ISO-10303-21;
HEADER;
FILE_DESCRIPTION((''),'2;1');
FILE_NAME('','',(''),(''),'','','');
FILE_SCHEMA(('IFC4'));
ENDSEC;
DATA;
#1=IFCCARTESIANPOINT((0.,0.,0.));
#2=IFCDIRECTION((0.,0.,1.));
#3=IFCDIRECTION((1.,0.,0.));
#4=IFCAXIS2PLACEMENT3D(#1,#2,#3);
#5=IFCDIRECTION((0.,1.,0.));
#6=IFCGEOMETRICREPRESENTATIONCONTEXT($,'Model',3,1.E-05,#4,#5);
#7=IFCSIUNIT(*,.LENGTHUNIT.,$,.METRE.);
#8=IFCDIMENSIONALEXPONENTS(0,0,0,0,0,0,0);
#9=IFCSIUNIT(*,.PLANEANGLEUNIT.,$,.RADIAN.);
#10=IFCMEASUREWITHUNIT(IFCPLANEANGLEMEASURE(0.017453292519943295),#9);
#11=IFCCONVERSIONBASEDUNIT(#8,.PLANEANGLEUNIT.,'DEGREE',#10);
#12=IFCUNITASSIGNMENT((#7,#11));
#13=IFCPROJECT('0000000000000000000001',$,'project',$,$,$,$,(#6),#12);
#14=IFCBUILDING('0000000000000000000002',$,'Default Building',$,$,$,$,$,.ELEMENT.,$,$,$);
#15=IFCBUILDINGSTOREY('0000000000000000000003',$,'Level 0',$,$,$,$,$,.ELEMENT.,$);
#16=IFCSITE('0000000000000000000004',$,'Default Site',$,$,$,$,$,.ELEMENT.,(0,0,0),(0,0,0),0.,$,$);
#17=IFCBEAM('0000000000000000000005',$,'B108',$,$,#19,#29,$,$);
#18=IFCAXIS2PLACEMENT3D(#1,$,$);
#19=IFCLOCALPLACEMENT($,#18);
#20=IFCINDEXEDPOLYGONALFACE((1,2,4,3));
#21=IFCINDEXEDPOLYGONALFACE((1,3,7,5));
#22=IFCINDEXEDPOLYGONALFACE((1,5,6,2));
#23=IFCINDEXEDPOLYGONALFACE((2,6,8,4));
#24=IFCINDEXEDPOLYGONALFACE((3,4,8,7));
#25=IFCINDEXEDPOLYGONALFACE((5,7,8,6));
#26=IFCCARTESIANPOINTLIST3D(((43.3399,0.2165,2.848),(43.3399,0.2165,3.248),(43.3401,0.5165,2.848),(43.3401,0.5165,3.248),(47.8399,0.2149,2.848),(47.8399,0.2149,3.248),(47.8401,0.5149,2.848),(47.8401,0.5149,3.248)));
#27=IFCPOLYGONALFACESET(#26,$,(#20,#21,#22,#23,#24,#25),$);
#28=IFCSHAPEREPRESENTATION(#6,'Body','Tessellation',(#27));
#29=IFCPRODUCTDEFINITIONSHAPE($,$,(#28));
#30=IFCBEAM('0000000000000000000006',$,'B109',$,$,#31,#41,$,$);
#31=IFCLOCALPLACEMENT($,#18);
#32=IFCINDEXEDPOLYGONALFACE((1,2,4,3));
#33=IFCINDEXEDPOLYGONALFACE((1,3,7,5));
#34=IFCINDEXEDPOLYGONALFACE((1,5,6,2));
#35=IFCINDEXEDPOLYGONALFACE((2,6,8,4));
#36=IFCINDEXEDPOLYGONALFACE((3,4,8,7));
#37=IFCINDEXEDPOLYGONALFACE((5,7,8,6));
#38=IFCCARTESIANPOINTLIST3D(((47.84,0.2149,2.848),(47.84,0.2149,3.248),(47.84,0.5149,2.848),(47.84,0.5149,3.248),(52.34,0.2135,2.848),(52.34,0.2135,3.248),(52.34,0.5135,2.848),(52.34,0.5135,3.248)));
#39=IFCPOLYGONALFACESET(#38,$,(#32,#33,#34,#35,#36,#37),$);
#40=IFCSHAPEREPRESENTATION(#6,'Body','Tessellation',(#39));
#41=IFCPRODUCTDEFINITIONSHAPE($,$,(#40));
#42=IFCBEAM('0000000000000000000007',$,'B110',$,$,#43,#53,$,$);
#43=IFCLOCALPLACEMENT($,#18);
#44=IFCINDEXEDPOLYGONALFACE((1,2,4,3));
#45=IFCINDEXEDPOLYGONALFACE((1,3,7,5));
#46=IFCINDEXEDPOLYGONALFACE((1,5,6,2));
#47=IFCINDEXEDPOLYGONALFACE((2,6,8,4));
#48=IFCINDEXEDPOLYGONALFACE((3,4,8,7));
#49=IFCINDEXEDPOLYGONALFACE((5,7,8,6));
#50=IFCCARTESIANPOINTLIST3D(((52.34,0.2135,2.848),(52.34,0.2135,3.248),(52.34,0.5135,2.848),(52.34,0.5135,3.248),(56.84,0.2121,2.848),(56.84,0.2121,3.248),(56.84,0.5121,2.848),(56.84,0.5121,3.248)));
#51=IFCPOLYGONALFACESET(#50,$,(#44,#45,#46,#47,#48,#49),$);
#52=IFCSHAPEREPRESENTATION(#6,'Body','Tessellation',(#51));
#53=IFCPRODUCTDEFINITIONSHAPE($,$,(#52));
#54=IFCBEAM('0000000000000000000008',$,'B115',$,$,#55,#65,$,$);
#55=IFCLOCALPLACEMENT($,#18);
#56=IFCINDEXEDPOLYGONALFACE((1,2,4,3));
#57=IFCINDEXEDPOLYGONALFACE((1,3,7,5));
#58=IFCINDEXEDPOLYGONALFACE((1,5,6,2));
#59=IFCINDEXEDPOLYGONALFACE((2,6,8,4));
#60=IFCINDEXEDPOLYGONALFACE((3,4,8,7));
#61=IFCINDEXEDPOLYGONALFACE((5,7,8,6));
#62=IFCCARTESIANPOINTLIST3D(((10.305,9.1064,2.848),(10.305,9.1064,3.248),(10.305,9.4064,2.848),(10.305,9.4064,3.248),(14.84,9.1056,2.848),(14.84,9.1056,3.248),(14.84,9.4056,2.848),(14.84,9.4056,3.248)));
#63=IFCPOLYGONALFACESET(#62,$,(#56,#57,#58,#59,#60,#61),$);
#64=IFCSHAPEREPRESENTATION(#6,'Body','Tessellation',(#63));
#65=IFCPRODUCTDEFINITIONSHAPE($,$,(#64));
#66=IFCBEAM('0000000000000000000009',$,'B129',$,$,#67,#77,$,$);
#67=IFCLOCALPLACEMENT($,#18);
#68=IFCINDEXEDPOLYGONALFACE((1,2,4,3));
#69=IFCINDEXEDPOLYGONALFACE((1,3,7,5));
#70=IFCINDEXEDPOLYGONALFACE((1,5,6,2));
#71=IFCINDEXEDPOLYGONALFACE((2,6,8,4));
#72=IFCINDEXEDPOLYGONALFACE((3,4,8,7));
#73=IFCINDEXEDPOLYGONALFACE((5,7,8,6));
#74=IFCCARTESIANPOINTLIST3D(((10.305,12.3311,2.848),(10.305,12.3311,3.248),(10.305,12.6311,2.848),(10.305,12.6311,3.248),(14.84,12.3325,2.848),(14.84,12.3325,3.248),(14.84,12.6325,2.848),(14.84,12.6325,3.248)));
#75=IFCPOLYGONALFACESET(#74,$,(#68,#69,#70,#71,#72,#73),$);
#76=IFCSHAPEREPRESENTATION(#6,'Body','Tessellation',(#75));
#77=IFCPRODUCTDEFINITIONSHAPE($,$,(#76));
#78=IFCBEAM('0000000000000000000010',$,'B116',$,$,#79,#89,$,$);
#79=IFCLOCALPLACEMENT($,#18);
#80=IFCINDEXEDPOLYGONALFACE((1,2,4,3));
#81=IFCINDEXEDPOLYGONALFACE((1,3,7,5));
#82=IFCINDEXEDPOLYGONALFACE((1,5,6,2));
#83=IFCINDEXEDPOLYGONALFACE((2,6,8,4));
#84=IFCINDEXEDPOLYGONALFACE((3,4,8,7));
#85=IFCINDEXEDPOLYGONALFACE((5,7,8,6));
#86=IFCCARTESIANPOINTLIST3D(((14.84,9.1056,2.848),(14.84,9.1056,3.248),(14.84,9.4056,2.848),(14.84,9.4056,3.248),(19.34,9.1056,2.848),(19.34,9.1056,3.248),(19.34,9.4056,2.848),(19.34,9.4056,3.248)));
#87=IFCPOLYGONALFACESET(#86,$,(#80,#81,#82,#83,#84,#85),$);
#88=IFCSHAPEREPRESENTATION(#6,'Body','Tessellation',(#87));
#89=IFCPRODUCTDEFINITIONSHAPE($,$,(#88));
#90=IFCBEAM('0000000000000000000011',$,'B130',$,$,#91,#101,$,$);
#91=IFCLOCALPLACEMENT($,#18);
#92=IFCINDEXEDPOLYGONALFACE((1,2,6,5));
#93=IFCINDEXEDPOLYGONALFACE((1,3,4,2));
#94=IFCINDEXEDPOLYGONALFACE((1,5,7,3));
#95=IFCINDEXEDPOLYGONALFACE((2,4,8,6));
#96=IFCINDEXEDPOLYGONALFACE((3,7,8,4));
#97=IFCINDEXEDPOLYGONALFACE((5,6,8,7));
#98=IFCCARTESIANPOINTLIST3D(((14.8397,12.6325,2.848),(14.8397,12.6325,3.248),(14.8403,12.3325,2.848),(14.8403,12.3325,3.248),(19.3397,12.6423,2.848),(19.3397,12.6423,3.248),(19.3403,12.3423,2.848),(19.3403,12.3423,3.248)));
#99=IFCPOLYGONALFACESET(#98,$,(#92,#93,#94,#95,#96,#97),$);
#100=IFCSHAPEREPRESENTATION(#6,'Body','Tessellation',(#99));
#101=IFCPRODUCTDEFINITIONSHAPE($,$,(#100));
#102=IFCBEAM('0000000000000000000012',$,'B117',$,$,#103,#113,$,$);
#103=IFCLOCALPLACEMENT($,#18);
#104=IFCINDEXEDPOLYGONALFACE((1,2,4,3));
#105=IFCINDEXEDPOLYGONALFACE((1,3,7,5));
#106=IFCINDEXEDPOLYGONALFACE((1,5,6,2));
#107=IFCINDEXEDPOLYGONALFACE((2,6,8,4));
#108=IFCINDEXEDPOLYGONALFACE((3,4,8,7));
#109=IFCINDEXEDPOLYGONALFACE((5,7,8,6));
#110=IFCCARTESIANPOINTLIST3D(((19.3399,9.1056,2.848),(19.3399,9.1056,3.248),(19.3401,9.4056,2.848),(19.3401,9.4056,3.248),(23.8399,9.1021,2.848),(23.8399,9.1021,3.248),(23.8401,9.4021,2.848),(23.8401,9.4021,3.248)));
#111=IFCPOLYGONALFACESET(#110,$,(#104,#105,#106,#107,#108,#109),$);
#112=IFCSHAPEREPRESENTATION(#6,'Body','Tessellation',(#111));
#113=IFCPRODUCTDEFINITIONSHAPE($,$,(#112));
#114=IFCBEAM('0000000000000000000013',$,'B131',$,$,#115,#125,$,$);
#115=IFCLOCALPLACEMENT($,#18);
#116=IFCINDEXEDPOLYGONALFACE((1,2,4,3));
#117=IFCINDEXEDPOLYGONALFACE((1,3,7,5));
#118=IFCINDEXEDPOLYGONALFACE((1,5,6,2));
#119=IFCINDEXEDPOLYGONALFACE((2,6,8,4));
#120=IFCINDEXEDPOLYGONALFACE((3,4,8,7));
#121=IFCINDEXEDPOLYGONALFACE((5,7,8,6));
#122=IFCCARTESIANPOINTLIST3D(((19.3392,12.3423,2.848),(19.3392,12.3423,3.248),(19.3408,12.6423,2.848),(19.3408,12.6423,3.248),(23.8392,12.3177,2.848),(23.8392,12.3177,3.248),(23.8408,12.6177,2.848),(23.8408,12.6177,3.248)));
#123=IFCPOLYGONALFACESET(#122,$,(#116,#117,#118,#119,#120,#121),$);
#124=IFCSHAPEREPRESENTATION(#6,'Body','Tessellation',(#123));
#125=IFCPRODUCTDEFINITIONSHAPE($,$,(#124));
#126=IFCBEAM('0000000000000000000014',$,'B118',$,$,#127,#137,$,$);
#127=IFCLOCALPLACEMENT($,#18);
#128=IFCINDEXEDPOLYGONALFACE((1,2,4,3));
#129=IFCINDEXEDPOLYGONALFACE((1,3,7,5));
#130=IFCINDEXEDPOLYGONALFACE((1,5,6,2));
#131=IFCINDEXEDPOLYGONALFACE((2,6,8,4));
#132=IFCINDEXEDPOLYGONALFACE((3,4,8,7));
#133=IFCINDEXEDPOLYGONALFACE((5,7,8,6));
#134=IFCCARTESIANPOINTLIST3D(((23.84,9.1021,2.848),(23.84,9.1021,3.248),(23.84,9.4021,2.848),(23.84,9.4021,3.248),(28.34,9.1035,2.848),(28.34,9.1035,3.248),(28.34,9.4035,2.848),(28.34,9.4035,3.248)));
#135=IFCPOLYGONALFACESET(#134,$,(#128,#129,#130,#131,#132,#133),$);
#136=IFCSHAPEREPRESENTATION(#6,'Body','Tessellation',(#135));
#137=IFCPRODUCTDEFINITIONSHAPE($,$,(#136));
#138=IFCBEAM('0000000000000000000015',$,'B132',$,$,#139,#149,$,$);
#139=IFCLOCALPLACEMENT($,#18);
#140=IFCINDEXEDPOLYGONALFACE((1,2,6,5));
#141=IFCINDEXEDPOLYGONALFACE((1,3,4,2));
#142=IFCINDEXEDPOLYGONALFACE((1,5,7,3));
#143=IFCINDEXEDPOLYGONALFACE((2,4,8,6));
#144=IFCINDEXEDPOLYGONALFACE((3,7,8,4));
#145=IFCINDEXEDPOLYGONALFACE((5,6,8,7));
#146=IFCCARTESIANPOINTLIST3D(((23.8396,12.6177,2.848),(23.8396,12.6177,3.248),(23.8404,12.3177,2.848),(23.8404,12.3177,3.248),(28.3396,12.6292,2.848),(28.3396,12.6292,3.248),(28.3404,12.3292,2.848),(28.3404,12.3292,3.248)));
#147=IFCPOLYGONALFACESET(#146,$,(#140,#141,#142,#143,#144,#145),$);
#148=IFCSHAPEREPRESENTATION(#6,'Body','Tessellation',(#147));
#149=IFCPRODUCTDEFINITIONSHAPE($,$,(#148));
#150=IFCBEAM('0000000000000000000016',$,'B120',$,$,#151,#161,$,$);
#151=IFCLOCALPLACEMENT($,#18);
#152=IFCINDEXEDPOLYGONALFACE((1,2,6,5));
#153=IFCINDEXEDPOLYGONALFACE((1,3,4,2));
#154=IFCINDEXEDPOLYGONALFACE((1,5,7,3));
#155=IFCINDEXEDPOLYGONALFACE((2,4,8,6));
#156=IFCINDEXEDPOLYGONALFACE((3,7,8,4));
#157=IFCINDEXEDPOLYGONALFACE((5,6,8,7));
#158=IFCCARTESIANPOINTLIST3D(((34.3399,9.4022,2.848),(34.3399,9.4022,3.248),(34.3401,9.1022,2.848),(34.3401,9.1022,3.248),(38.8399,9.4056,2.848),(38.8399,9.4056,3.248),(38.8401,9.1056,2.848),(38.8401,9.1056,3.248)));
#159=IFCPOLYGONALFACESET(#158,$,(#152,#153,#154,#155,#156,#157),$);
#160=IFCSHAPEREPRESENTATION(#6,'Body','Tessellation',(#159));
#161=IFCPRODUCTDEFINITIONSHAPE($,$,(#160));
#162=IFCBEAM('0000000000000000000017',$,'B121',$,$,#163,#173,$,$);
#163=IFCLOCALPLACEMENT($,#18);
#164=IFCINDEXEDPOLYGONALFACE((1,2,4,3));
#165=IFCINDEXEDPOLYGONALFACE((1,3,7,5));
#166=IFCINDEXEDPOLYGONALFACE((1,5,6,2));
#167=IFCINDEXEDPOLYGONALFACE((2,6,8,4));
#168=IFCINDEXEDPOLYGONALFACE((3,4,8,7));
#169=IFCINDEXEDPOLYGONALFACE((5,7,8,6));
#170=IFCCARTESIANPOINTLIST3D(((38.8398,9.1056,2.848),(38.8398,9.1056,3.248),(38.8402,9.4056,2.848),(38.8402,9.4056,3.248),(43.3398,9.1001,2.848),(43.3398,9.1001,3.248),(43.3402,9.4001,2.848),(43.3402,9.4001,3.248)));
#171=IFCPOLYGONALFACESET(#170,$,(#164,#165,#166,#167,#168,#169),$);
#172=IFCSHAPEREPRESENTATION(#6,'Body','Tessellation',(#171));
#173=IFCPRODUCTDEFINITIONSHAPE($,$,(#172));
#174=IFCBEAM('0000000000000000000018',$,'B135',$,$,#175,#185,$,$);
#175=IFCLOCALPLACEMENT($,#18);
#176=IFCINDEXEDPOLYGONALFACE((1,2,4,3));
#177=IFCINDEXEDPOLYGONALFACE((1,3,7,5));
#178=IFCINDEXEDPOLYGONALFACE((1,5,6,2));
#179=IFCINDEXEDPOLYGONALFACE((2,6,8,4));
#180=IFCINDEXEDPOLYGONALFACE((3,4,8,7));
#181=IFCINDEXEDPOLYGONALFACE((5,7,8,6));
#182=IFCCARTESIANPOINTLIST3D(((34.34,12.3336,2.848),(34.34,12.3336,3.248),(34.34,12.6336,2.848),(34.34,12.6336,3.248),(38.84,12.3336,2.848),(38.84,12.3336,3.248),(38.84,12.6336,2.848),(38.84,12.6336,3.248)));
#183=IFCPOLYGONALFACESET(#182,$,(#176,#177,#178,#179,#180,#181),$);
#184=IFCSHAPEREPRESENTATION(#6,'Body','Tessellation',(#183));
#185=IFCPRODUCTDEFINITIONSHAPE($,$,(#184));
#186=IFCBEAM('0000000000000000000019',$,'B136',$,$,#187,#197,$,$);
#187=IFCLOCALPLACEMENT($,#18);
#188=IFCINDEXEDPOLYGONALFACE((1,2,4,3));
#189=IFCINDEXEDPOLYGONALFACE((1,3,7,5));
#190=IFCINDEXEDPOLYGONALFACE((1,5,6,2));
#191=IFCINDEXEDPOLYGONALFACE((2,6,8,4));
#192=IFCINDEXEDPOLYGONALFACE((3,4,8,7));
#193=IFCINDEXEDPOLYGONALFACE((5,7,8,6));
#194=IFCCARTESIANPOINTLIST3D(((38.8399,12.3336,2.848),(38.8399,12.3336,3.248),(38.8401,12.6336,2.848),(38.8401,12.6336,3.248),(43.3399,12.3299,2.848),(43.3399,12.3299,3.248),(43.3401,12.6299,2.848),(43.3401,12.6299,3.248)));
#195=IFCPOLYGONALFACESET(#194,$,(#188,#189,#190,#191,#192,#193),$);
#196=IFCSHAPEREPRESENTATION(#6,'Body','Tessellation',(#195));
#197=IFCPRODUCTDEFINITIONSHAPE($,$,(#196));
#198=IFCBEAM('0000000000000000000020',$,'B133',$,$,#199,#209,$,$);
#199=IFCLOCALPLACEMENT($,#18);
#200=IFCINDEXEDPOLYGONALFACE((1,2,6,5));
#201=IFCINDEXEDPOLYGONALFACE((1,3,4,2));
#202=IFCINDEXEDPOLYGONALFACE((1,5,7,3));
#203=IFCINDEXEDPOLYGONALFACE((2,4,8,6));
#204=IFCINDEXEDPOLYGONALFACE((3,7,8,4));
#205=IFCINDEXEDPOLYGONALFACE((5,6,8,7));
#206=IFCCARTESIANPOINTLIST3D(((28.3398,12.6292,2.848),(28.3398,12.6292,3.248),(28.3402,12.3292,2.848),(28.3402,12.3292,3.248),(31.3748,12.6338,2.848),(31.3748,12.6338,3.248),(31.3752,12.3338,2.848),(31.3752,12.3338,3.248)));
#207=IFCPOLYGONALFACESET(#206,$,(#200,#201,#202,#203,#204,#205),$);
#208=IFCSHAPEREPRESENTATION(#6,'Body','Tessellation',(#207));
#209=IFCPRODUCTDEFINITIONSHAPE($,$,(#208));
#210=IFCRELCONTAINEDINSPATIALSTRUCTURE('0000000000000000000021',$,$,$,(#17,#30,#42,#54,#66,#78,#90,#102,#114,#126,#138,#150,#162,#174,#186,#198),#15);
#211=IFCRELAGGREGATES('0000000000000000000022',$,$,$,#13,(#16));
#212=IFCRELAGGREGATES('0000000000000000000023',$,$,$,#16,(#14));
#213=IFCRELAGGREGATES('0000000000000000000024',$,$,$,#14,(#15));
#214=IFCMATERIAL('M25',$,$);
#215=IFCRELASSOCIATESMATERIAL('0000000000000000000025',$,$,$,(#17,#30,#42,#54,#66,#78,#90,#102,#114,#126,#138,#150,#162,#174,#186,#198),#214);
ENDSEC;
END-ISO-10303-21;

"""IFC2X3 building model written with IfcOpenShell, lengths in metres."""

from ifc_helpers import new_model, entity, si_unit, converted_unit, direction, frame, frame_2d, origin_with_axes, place, context, project, spatial, rectangle, extrude, material, element, save


model = new_model("IFC2X3")

# Units and contexts
model_context = context("Model", 3, precision=1e-05, world=origin_with_axes(), true_north=direction((0.0, 1.0, 0.0)))
ifc_project = project(units=[si_unit("LENGTHUNIT", "METRE"), converted_unit("PLANEANGLEUNIT", "DEGREE", entity("IfcPlaneAngleMeasure", 0.017453292519943295), si_unit("PLANEANGLEUNIT", "RADIAN"), dimensions=[0, 0, 0, 0, 0, 0, 0])], contexts=[model_context])

# Site, building, storey
site = spatial("IfcSite", under=ifc_project, Name="Default Site", CompositionType="ELEMENT", RefLatitude=(0, 0, 0), RefLongitude=(0, 0, 0), RefElevation=0.0)
building = spatial("IfcBuilding", under=site, Name="Default Building", CompositionType="ELEMENT")
storey = spatial("IfcBuildingStorey", under=building, Name="Level 0", CompositionType="ELEMENT")

# Beams
ifc_material = material(Name="M25")
placement = place(None, origin_with_axes())
element("IfcBeam", 1, at=placement, inside=storey, material=ifc_material, Name="B108", context=model_context, shape_type="SweptSolid", body=[
    extrude(rectangle(XDim=0.3, YDim=0.4, at=frame_2d((0.0, 0.0), x_axis=(0.0, 1.0, 0.0))), frame((43.34, 0.3665, 3.048), z_axis=(1.0, -0.000358, 0.0), x_axis=(0.0, 0.0, -1.0)), (0.0, 0.0, 1.0), 4.5),
])
element("IfcBeam", 2, at=placement, inside=storey, material=ifc_material, Name="B109", context=model_context, shape_type="SweptSolid", body=[
    extrude(rectangle(XDim=0.3, YDim=0.4, at=frame_2d((0.0, 0.0), x_axis=(0.0, 1.0, 0.0))), frame((47.84, 0.3649, 3.048), z_axis=(1.0, -0.000297, 0.0), x_axis=(0.0, 0.0, -1.0)), (0.0, 0.0, 1.0), 4.5),
])
element("IfcBeam", 3, at=placement, inside=storey, material=ifc_material, Name="B110", context=model_context, shape_type="SweptSolid", body=[
    extrude(rectangle(XDim=0.3, YDim=0.4, at=frame_2d((0.0, 0.0), x_axis=(0.0, 1.0, 0.0))), frame((52.34, 0.3635, 3.048), z_axis=(1.0, -0.000311, 0.0), x_axis=(0.0, 0.0, -1.0)), (0.0, 0.0, 1.0), 4.5),
])
element("IfcBeam", 4, at=placement, inside=storey, material=ifc_material, Name="B115", context=model_context, shape_type="SweptSolid", body=[
    extrude(rectangle(XDim=0.3, YDim=0.4, at=frame_2d((0.0, 0.0), x_axis=(0.0, 1.0, 0.0))), frame((10.305, 9.2564, 3.048), z_axis=(1.0, -0.000182, 0.0), x_axis=(0.0, 0.0, -1.0)), (0.0, 0.0, 1.0), 4.535),
])
element("IfcBeam", 5, at=placement, inside=storey, material=ifc_material, Name="B129", context=model_context, shape_type="SweptSolid", body=[
    extrude(rectangle(XDim=0.3, YDim=0.4, at=frame_2d((0.0, 0.0), x_axis=(0.0, 1.0, 0.0))), frame((10.305, 12.4811, 3.048), z_axis=(1.0, 0.000301, 0.0), x_axis=(0.0, 0.0, -1.0)), (0.0, 0.0, 1.0), 4.535),
])
element("IfcBeam", 6, at=placement, inside=storey, material=ifc_material, Name="B116", context=model_context, shape_type="SweptSolid", body=[
    extrude(rectangle(XDim=0.3, YDim=0.4, at=frame_2d((0.0, 0.0), x_axis=(0.0, 1.0, 0.0))), frame((14.84, 9.2556, 3.048), z_axis=(1.0, 0.000013, 0.0), x_axis=(0.0, 0.0, -1.0)), (0.0, 0.0, 1.0), 4.5),
])
element("IfcBeam", 7, at=placement, inside=storey, material=ifc_material, Name="B130", context=model_context, shape_type="SweptSolid", body=[
    extrude(rectangle(XDim=0.3, YDim=0.4, at=frame_2d((0.0, 0.0), x_axis=(0.0, 1.0, 0.0))), frame((14.84, 12.4825, 3.048), z_axis=(0.999998, 0.002176, 0.0), x_axis=(0.0, 0.0, -1.0)), (0.0, 0.0, 1.0), 4.5),
])
element("IfcBeam", 8, at=placement, inside=storey, material=ifc_material, Name="B117", context=model_context, shape_type="SweptSolid", body=[
    extrude(rectangle(XDim=0.3, YDim=0.4, at=frame_2d((0.0, 0.0), x_axis=(0.0, 1.0, 0.0))), frame((19.34, 9.2556, 3.048), z_axis=(1.0, -0.000779, 0.0), x_axis=(0.0, 0.0, -1.0)), (0.0, 0.0, 1.0), 4.5),
])
element("IfcBeam", 9, at=placement, inside=storey, material=ifc_material, Name="B131", context=model_context, shape_type="SweptSolid", body=[
    extrude(rectangle(XDim=0.3, YDim=0.4, at=frame_2d((0.0, 0.0), x_axis=(0.0, 1.0, 0.0))), frame((19.34, 12.4923, 3.048), z_axis=(0.999985, -0.005463, 0.0), x_axis=(0.0, 0.0, -1.0)), (0.0, 0.0, 1.0), 4.5001),
])
element("IfcBeam", 10, at=placement, inside=storey, material=ifc_material, Name="B118", context=model_context, shape_type="SweptSolid", body=[
    extrude(rectangle(XDim=0.3, YDim=0.4, at=frame_2d((0.0, 0.0), x_axis=(0.0, 1.0, 0.0))), frame((23.84, 9.2521, 3.048), z_axis=(1.0, 0.000307, 0.0), x_axis=(0.0, 0.0, -1.0)), (0.0, 0.0, 1.0), 4.5),
])
element("IfcBeam", 11, at=placement, inside=storey, material=ifc_material, Name="B132", context=model_context, shape_type="SweptSolid", body=[
    extrude(rectangle(XDim=0.3, YDim=0.4, at=frame_2d((0.0, 0.0), x_axis=(0.0, 1.0, 0.0))), frame((23.84, 12.4677, 3.048), z_axis=(0.999997, 0.002551, 0.0), x_axis=(0.0, 0.0, -1.0)), (0.0, 0.0, 1.0), 4.5),
])
element("IfcBeam", 12, at=placement, inside=storey, material=ifc_material, Name="B120", context=model_context, shape_type="SweptSolid", body=[
    extrude(rectangle(XDim=0.3, YDim=0.4, at=frame_2d((0.0, 0.0), x_axis=(0.0, 1.0, 0.0))), frame((34.34, 9.2522, 3.048), z_axis=(1.0, 0.000748, 0.0), x_axis=(0.0, 0.0, -1.0)), (0.0, 0.0, 1.0), 4.5),
])
element("IfcBeam", 13, at=placement, inside=storey, material=ifc_material, Name="B121", context=model_context, shape_type="SweptSolid", body=[
    extrude(rectangle(XDim=0.3, YDim=0.4, at=frame_2d((0.0, 0.0), x_axis=(0.0, 1.0, 0.0))), frame((38.84, 9.2556, 3.048), z_axis=(0.999999, -0.001227, 0.0), x_axis=(0.0, 0.0, -1.0)), (0.0, 0.0, 1.0), 4.5),
])
element("IfcBeam", 14, at=placement, inside=storey, material=ifc_material, Name="B135", context=model_context, shape_type="SweptSolid", body=[
    extrude(rectangle(XDim=0.3, YDim=0.4, at=frame_2d((0.0, 0.0), x_axis=(0.0, 1.0, 0.0))), frame((34.34, 12.4836, 3.048), z_axis=(1.0, -0.000008, 0.0), x_axis=(0.0, 0.0, -1.0)), (0.0, 0.0, 1.0), 4.5),
])
element("IfcBeam", 15, at=placement, inside=storey, material=ifc_material, Name="B136", context=model_context, shape_type="SweptSolid", body=[
    extrude(rectangle(XDim=0.3, YDim=0.4, at=frame_2d((0.0, 0.0), x_axis=(0.0, 1.0, 0.0))), frame((38.84, 12.4836, 3.048), z_axis=(1.0, -0.000826, 0.0), x_axis=(0.0, 0.0, -1.0)), (0.0, 0.0, 1.0), 4.5),
])
element("IfcBeam", 16, at=placement, inside=storey, material=ifc_material, Name="B133", context=model_context, shape_type="SweptSolid", body=[
    extrude(rectangle(XDim=0.3, YDim=0.4, at=frame_2d((0.0, 0.0), x_axis=(0.0, 1.0, 0.0))), frame((28.34, 12.4792, 3.048), z_axis=(0.999999, 0.001542, 0.0), x_axis=(0.0, 0.0, -1.0)), (0.0, 0.0, 1.0), 3.035),
])

save(model, "model.ifc")
